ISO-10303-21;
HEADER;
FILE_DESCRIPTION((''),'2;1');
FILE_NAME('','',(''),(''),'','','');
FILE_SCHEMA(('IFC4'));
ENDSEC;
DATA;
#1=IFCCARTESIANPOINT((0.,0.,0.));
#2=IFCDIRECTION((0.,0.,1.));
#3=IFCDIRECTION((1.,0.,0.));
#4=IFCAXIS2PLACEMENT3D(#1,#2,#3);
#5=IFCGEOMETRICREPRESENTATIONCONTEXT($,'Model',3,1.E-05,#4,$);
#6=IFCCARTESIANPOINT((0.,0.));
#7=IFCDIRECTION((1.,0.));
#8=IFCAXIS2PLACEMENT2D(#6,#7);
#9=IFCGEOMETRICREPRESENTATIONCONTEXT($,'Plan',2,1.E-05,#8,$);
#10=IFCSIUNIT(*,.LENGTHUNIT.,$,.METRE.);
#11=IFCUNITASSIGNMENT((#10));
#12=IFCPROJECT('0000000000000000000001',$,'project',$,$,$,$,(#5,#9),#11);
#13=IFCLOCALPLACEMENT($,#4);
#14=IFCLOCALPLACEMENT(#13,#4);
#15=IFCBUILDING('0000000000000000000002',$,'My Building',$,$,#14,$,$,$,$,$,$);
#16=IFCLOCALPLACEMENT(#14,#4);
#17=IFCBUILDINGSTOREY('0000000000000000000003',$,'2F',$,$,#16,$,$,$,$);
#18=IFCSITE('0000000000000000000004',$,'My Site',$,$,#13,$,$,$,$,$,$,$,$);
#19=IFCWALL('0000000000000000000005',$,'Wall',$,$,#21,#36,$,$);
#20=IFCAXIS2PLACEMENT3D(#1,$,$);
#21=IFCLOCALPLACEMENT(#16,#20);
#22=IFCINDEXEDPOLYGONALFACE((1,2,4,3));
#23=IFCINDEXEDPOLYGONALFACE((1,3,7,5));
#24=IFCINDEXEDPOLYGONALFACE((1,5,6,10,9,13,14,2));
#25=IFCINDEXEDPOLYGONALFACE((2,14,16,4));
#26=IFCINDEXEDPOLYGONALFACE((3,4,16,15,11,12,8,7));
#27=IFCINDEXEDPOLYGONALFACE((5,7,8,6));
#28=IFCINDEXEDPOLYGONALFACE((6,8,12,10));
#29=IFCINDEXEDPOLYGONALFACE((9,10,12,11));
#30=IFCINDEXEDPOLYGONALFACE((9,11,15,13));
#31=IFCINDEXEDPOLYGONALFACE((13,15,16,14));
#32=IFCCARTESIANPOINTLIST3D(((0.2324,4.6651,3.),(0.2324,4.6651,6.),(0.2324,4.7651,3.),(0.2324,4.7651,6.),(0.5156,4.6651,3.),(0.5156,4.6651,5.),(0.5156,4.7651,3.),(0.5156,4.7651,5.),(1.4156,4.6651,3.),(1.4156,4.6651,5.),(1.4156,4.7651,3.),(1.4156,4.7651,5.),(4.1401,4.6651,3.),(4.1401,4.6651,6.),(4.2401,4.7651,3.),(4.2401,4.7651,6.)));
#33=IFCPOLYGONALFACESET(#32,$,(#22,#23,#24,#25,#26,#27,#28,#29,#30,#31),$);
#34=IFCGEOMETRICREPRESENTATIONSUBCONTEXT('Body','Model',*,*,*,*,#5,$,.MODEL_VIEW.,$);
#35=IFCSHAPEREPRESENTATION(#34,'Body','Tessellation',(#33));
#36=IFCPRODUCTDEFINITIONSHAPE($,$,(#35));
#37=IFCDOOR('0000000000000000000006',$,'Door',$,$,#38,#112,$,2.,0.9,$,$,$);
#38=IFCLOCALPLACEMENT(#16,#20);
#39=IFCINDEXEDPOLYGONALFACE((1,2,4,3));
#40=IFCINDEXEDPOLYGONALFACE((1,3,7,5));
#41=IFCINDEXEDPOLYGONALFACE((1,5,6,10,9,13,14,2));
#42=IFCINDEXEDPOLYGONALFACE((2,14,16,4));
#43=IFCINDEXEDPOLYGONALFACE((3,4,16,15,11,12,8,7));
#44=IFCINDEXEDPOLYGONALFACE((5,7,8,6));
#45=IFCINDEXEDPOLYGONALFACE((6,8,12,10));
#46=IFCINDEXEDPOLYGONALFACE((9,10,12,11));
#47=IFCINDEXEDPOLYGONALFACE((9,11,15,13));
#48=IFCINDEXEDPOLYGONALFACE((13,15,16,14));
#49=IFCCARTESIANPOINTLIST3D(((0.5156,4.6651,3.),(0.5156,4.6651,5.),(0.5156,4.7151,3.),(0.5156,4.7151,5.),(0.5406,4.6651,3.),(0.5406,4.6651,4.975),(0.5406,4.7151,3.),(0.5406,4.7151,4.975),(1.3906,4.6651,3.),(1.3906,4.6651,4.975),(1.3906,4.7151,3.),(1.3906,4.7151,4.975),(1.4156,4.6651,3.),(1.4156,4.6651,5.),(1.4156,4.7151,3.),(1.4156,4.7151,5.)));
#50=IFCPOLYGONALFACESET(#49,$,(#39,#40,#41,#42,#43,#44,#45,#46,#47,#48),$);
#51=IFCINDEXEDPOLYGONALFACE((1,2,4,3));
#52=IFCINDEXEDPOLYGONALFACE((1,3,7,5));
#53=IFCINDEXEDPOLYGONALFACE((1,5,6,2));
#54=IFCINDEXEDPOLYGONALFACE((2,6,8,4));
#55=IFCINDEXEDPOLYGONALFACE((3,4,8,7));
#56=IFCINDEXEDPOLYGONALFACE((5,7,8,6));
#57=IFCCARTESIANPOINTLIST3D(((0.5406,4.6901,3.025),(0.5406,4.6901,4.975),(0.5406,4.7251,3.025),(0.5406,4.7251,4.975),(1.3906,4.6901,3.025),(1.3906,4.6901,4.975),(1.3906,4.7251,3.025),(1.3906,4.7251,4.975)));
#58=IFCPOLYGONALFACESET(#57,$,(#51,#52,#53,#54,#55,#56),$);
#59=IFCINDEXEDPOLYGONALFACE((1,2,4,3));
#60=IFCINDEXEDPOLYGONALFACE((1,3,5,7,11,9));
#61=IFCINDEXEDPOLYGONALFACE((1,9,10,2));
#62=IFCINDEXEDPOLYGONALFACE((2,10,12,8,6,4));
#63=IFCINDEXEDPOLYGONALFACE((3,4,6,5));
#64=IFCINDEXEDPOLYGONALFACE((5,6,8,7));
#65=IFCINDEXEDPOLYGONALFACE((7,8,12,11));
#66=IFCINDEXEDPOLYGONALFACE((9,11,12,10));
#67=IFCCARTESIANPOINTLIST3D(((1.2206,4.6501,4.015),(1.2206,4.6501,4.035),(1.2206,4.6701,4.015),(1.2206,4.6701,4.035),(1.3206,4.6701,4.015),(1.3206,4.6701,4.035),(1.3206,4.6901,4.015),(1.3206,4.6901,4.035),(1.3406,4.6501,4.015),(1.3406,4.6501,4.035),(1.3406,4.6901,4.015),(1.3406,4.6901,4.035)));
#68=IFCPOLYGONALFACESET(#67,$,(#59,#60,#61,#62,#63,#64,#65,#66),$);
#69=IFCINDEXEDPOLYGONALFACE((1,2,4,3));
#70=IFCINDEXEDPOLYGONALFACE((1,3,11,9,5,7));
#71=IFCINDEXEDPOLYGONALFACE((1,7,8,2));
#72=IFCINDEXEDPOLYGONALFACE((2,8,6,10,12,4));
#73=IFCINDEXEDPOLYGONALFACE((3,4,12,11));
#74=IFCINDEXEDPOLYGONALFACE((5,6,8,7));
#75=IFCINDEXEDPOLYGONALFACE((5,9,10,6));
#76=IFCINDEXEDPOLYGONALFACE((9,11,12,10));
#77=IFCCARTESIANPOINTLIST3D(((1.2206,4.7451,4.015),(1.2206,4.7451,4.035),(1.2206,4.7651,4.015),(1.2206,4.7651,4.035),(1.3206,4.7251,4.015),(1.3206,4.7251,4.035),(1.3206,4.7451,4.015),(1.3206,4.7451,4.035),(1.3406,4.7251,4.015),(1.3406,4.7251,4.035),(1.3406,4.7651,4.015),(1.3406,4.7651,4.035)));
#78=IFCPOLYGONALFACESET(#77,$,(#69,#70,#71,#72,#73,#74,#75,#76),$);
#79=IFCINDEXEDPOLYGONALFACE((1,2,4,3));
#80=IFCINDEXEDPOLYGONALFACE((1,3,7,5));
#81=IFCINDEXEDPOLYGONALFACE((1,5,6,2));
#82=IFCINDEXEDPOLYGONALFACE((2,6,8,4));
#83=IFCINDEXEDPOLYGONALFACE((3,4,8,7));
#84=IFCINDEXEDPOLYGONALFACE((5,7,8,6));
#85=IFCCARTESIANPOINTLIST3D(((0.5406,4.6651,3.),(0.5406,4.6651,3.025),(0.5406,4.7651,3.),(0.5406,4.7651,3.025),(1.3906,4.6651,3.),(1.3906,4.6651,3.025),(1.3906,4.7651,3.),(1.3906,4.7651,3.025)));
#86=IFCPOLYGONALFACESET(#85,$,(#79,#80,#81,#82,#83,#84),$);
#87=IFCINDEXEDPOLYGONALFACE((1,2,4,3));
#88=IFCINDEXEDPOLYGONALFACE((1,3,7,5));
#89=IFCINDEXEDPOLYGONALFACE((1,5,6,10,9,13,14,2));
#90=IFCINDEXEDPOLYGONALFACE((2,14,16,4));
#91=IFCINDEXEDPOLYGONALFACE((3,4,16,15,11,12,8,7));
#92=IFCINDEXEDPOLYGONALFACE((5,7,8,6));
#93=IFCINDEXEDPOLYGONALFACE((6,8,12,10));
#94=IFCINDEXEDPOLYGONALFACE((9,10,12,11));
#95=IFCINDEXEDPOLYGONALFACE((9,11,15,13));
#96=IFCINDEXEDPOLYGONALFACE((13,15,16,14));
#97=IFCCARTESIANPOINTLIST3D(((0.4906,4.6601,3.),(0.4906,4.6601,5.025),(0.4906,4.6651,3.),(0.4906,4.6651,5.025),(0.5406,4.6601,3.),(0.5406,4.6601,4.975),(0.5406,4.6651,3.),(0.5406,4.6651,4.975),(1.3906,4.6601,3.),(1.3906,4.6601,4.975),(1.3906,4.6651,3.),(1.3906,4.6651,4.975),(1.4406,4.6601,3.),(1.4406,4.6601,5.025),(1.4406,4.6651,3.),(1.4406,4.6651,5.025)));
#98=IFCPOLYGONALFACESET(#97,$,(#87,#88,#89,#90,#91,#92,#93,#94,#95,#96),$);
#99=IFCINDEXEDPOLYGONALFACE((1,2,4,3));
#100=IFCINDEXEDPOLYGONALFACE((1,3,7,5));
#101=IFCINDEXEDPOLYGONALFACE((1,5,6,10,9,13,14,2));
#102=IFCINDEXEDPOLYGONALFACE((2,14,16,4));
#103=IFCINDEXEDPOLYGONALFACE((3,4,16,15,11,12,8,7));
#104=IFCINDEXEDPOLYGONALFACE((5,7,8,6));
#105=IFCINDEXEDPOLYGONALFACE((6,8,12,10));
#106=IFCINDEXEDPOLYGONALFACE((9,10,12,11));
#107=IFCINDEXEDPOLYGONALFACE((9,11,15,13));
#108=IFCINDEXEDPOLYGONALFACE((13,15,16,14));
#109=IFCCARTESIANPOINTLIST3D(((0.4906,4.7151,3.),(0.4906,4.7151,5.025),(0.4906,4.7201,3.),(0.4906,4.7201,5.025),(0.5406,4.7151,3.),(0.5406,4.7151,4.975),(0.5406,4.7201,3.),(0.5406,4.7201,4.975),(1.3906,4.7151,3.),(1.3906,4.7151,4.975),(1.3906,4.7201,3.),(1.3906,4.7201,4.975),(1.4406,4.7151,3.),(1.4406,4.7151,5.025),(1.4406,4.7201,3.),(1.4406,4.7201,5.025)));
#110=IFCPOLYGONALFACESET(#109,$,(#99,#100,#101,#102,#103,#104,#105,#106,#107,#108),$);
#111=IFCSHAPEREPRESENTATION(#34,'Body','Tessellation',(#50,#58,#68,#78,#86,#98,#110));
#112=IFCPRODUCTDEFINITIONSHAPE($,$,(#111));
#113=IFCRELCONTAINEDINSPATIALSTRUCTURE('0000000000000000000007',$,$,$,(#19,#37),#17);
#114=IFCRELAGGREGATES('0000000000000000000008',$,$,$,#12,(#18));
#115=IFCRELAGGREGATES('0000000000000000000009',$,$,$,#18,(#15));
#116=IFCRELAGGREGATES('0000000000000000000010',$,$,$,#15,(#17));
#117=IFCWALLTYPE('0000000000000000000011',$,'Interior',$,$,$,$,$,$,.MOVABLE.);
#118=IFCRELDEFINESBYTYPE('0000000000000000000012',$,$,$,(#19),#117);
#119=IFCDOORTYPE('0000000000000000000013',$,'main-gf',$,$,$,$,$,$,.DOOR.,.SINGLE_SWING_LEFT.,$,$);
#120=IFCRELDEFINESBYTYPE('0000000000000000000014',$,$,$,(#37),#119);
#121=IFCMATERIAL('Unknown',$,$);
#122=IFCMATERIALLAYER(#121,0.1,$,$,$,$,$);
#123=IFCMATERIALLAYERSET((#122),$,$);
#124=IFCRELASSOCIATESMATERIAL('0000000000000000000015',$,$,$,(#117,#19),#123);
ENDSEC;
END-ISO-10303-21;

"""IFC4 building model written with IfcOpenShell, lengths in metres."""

from ifc_helpers import new_model, entity, si_unit, frame, origin_with_axes, origin_2d_with_axis, place, context, subcontext, project, spatial, line, indexed_curve, outline, extrude, shape, source, transform, mapped, material, layer, layer_set, layer_usage, type_object, type_shapes, element, fill, save


model = new_model("IFC4")

# Units and contexts
model_context = context("Model", 3, precision=1e-05, world=origin_with_axes())
plan_context = context("Plan", 2, precision=1e-05, world=origin_2d_with_axis())
body_context_1 = subcontext(model_context, "Body", "Model", "MODEL_VIEW")
body_context_2 = subcontext(plan_context, "Body", "Plan", "PLAN_VIEW")
ifc_project = project(units=[si_unit("LENGTHUNIT", "METRE")], contexts=[model_context, plan_context])

# Site, building, storey
site_placement = place(None, origin_with_axes())
site = spatial("IfcSite", under=ifc_project, at=site_placement, Name="My Site")
building_placement = place(site_placement, origin_with_axes())
building = spatial("IfcBuilding", under=site, at=building_placement, Name="My Building")
storey_placement = place(building_placement, origin_with_axes())
storey = spatial("IfcBuildingStorey", under=building, at=storey_placement, Name="2F")

# Shared definitions
ifc_material = material(Name="Unknown")

# Shared definitions
ifc_layer_1 = layer(ifc_material, 0.1)
ifc_layer_set_1 = layer_set([ifc_layer_1])
wall_type = type_object("IfcWallType", Name="Interior", PredefinedType="MOVABLE", material=ifc_layer_set_1)

# Shared definitions
shared_shape_1 = source(origin_with_axes(), body_context_1, "Body", "SweptSolid", [
    extrude(outline(indexed_curve([(0.0, 0.0), (0.9, 0.0), (0.9, 2.0), (0.0, 2.0)], segments=[line(1, 2, 3, 4, 1)])), frame((0.0, -0.6, 0.0), z_axis=(0.0, -1.0, 0.0), x_axis=(1.0, 0.0, 0.0)), (0.0, 0.0, -1.0), 1.2),
])
door_type = type_object("IfcDoorType", Name="main-gf", OperationType="SINGLE_SWING_LEFT", PredefinedType="DOOR")
shared_shape_2 = source(origin_with_axes(), body_context_1, "Body", "SweptSolid", [
    extrude(outline(indexed_curve([(0.0, 0.0), (0.0, 2.0), (0.9, 2.0), (0.9, 0.0), (0.875, 0.0), (0.875, 1.975), (0.025, 1.975), (0.025, 0.0)], segments=[line(1, 2, 3, 4, 5, 6, 7, 8, 1)])), frame((0.0, 0.0, 0.0), z_axis=(0.0, -1.0, 0.0), x_axis=(1.0, 0.0, 0.0)), (0.0, 0.0, -1.0), 0.05),
    extrude(outline(indexed_curve([(0.0, 0.0), (0.85, 0.0), (0.85, 0.035), (0.0, 0.035)], segments=[line(1, 2, 3, 4, 1)])), frame((0.025, 0.025, 0.025), z_axis=(0.0, 0.0, 1.0), x_axis=(1.0, 0.0, 0.0)), (0.0, 0.0, 1.0), 1.95),
    extrude(outline(indexed_curve([(0.0, 0.0), (0.0, -0.04), (-0.12, -0.04), (-0.12, -0.02), (-0.02, -0.02), (-0.02, 0.0)], segments=[line(1, 2, 3, 4, 5, 6, 1)])), frame((0.825, 0.025, 1.015), z_axis=(0.0, 0.0, 1.0), x_axis=(1.0, 0.0, 0.0)), (0.0, 0.0, 1.0), 0.02),
    extrude(outline(indexed_curve([(0.0, 0.0), (0.0, 0.04), (-0.12, 0.04), (-0.12, 0.02), (-0.02, 0.02), (-0.02, 0.0)], segments=[line(1, 2, 3, 4, 5, 6, 1)])), frame((0.825, 0.06, 1.015), z_axis=(0.0, 0.0, 1.0), x_axis=(1.0, 0.0, 0.0)), (0.0, 0.0, 1.0), 0.02),
    extrude(outline(indexed_curve([(0.0, 0.0), (0.85, 0.0), (0.85, 0.1), (0.0, 0.1)], segments=[line(1, 2, 3, 4, 1)])), frame((0.025, 0.0, 0.0), z_axis=(0.0, 0.0, 1.0), x_axis=(1.0, 0.0, 0.0)), (0.0, 0.0, 1.0), 0.025),
    extrude(outline(indexed_curve([(0.0, 0.0), (0.0, 2.025), (0.95, 2.025), (0.95, 0.0), (0.9, 0.0), (0.9, 1.975), (0.05, 1.975), (0.05, 0.0)], segments=[line(1, 2, 3, 4, 5, 6, 7, 8, 1)])), frame((-0.025, -0.005, 0.0), z_axis=(0.0, -1.0, 0.0), x_axis=(1.0, 0.0, 0.0)), (0.0, 0.0, -1.0), 0.005),
    extrude(outline(indexed_curve([(0.0, 0.0), (0.0, 2.025), (0.95, 2.025), (0.95, 0.0), (0.9, 0.0), (0.9, 1.975), (0.05, 1.975), (0.05, 0.0)], segments=[line(1, 2, 3, 4, 5, 6, 7, 8, 1)])), frame((-0.025, 0.05, 0.0), z_axis=(0.0, -1.0, 0.0), x_axis=(1.0, 0.0, 0.0)), (0.0, 0.0, -1.0), 0.005),
])
shared_shape_3 = source(origin_with_axes(), body_context_2, "Body", "Curve2D", [
    entity("IfcIndexedPolyCurve", entity("IfcCartesianPointList2D", [[0.0, 0.0], [0.025, 0.0], [0.025, 0.05], [0.0, 0.05]]), [entity("IfcLineIndex", [1, 2, 3, 4, 1])]),
    entity("IfcIndexedPolyCurve", entity("IfcCartesianPointList2D", [[0.9, 0.0], [0.875, 0.0], [0.875, 0.05], [0.9, 0.05]]), [entity("IfcLineIndex", [1, 2, 3, 4, 1])]),
    entity("IfcIndexedPolyCurve", entity("IfcCartesianPointList2D", [[0.025, 0.05], [0.025, -0.8], [0.06, -0.8]])),
    entity("IfcTrimmedCurve", entity("IfcEllipse", entity("IfcAxis2Placement2D", entity("IfcCartesianPoint", [0.06, 0.05]), entity("IfcDirection", [1.0, 0.0])), 0.815, 0.85), [entity("IfcCartesianPoint", [0.06, -0.8])], [entity("IfcCartesianPoint", [0.06, 0.9])], True, "CARTESIAN"),
    entity("IfcIndexedPolyCurve", entity("IfcCartesianPointList2D", [[0.025, 0.05], [0.06, 0.05], [0.06, 0.9], [0.025, 0.9]]), [entity("IfcLineIndex", [1, 2, 3, 4, 1])]),
])
type_shapes(door_type, [shared_shape_2, shared_shape_3])

# Wall, opening, door
ifc_layer_usage_1 = layer_usage(ifc_layer_set_1, "AXIS2", "POSITIVE", 0.0)
wall_1_placement = place(storey_placement, frame((4.1401, 4.7651, 3.0), z_axis=(0.0, 0.0, 1.0), x_axis=(-1.0, 0.0, 0.0)))
wall_1 = element("IfcWall", 1, at=wall_1_placement, inside=storey, type_object=wall_type, material=ifc_layer_usage_1, Name="Wall", context=body_context_1, shape_type="SweptSolid", body=[
    extrude(outline(indexed_curve([(-0.1, 0.0), (0.0, 0.1), (3.9077, 0.1), (3.9077, 0.0)], segments=[line(1, 2, 3, 4, 1)])), origin_with_axes(), (0.0, 0.0, 1.0), 3.0),
])
opening_1_placement = place(wall_1_placement, frame((3.6245, 0.1, 0.0), z_axis=(0.0, 0.0, 1.0), x_axis=(-1.0, 0.0, 0.0)))
opening_1 = element("IfcOpeningElement", 2, at=opening_1_placement, cuts=wall_1, PredefinedType="OPENING", context=body_context_1, shape_type="MappedRepresentation", body=[
    mapped(shared_shape_1, transform((0.0, 0.0, 0.0), x_axis=(1.0, 0.0, 0.0), y_axis=(0.0, 1.0, 0.0), z_axis=(0.0, 0.0, 1.0), scale=1.0)),
])
door_1_placement = place(opening_1_placement, frame((0.0, 0.0, 0.0), z_axis=(0.0, 0.0, 1.0), x_axis=(1.0, 0.0, 0.0)))
door_1 = element("IfcDoor", 3, at=door_1_placement, inside=storey, type_object=door_type, Name="Door", OverallHeight=2.0, OverallWidth=0.9, shapes=[
    shape(body_context_1, "Body", "MappedRepresentation", [mapped(shared_shape_2, transform((0.0, 0.0, 0.0), x_axis=(1.0, 0.0, 0.0), y_axis=(0.0, 1.0, 0.0), z_axis=(0.0, 0.0, 1.0), scale=1.0))]),
    shape(body_context_2, "Body", "MappedRepresentation", [mapped(shared_shape_3, transform((0.0, 0.0, 0.0), x_axis=(1.0, 0.0, 0.0), y_axis=(0.0, 1.0, 0.0), z_axis=(0.0, 0.0, 1.0), scale=1.0))]),
])
fill(opening_1, door_1)

save(model, "model.ifc")
